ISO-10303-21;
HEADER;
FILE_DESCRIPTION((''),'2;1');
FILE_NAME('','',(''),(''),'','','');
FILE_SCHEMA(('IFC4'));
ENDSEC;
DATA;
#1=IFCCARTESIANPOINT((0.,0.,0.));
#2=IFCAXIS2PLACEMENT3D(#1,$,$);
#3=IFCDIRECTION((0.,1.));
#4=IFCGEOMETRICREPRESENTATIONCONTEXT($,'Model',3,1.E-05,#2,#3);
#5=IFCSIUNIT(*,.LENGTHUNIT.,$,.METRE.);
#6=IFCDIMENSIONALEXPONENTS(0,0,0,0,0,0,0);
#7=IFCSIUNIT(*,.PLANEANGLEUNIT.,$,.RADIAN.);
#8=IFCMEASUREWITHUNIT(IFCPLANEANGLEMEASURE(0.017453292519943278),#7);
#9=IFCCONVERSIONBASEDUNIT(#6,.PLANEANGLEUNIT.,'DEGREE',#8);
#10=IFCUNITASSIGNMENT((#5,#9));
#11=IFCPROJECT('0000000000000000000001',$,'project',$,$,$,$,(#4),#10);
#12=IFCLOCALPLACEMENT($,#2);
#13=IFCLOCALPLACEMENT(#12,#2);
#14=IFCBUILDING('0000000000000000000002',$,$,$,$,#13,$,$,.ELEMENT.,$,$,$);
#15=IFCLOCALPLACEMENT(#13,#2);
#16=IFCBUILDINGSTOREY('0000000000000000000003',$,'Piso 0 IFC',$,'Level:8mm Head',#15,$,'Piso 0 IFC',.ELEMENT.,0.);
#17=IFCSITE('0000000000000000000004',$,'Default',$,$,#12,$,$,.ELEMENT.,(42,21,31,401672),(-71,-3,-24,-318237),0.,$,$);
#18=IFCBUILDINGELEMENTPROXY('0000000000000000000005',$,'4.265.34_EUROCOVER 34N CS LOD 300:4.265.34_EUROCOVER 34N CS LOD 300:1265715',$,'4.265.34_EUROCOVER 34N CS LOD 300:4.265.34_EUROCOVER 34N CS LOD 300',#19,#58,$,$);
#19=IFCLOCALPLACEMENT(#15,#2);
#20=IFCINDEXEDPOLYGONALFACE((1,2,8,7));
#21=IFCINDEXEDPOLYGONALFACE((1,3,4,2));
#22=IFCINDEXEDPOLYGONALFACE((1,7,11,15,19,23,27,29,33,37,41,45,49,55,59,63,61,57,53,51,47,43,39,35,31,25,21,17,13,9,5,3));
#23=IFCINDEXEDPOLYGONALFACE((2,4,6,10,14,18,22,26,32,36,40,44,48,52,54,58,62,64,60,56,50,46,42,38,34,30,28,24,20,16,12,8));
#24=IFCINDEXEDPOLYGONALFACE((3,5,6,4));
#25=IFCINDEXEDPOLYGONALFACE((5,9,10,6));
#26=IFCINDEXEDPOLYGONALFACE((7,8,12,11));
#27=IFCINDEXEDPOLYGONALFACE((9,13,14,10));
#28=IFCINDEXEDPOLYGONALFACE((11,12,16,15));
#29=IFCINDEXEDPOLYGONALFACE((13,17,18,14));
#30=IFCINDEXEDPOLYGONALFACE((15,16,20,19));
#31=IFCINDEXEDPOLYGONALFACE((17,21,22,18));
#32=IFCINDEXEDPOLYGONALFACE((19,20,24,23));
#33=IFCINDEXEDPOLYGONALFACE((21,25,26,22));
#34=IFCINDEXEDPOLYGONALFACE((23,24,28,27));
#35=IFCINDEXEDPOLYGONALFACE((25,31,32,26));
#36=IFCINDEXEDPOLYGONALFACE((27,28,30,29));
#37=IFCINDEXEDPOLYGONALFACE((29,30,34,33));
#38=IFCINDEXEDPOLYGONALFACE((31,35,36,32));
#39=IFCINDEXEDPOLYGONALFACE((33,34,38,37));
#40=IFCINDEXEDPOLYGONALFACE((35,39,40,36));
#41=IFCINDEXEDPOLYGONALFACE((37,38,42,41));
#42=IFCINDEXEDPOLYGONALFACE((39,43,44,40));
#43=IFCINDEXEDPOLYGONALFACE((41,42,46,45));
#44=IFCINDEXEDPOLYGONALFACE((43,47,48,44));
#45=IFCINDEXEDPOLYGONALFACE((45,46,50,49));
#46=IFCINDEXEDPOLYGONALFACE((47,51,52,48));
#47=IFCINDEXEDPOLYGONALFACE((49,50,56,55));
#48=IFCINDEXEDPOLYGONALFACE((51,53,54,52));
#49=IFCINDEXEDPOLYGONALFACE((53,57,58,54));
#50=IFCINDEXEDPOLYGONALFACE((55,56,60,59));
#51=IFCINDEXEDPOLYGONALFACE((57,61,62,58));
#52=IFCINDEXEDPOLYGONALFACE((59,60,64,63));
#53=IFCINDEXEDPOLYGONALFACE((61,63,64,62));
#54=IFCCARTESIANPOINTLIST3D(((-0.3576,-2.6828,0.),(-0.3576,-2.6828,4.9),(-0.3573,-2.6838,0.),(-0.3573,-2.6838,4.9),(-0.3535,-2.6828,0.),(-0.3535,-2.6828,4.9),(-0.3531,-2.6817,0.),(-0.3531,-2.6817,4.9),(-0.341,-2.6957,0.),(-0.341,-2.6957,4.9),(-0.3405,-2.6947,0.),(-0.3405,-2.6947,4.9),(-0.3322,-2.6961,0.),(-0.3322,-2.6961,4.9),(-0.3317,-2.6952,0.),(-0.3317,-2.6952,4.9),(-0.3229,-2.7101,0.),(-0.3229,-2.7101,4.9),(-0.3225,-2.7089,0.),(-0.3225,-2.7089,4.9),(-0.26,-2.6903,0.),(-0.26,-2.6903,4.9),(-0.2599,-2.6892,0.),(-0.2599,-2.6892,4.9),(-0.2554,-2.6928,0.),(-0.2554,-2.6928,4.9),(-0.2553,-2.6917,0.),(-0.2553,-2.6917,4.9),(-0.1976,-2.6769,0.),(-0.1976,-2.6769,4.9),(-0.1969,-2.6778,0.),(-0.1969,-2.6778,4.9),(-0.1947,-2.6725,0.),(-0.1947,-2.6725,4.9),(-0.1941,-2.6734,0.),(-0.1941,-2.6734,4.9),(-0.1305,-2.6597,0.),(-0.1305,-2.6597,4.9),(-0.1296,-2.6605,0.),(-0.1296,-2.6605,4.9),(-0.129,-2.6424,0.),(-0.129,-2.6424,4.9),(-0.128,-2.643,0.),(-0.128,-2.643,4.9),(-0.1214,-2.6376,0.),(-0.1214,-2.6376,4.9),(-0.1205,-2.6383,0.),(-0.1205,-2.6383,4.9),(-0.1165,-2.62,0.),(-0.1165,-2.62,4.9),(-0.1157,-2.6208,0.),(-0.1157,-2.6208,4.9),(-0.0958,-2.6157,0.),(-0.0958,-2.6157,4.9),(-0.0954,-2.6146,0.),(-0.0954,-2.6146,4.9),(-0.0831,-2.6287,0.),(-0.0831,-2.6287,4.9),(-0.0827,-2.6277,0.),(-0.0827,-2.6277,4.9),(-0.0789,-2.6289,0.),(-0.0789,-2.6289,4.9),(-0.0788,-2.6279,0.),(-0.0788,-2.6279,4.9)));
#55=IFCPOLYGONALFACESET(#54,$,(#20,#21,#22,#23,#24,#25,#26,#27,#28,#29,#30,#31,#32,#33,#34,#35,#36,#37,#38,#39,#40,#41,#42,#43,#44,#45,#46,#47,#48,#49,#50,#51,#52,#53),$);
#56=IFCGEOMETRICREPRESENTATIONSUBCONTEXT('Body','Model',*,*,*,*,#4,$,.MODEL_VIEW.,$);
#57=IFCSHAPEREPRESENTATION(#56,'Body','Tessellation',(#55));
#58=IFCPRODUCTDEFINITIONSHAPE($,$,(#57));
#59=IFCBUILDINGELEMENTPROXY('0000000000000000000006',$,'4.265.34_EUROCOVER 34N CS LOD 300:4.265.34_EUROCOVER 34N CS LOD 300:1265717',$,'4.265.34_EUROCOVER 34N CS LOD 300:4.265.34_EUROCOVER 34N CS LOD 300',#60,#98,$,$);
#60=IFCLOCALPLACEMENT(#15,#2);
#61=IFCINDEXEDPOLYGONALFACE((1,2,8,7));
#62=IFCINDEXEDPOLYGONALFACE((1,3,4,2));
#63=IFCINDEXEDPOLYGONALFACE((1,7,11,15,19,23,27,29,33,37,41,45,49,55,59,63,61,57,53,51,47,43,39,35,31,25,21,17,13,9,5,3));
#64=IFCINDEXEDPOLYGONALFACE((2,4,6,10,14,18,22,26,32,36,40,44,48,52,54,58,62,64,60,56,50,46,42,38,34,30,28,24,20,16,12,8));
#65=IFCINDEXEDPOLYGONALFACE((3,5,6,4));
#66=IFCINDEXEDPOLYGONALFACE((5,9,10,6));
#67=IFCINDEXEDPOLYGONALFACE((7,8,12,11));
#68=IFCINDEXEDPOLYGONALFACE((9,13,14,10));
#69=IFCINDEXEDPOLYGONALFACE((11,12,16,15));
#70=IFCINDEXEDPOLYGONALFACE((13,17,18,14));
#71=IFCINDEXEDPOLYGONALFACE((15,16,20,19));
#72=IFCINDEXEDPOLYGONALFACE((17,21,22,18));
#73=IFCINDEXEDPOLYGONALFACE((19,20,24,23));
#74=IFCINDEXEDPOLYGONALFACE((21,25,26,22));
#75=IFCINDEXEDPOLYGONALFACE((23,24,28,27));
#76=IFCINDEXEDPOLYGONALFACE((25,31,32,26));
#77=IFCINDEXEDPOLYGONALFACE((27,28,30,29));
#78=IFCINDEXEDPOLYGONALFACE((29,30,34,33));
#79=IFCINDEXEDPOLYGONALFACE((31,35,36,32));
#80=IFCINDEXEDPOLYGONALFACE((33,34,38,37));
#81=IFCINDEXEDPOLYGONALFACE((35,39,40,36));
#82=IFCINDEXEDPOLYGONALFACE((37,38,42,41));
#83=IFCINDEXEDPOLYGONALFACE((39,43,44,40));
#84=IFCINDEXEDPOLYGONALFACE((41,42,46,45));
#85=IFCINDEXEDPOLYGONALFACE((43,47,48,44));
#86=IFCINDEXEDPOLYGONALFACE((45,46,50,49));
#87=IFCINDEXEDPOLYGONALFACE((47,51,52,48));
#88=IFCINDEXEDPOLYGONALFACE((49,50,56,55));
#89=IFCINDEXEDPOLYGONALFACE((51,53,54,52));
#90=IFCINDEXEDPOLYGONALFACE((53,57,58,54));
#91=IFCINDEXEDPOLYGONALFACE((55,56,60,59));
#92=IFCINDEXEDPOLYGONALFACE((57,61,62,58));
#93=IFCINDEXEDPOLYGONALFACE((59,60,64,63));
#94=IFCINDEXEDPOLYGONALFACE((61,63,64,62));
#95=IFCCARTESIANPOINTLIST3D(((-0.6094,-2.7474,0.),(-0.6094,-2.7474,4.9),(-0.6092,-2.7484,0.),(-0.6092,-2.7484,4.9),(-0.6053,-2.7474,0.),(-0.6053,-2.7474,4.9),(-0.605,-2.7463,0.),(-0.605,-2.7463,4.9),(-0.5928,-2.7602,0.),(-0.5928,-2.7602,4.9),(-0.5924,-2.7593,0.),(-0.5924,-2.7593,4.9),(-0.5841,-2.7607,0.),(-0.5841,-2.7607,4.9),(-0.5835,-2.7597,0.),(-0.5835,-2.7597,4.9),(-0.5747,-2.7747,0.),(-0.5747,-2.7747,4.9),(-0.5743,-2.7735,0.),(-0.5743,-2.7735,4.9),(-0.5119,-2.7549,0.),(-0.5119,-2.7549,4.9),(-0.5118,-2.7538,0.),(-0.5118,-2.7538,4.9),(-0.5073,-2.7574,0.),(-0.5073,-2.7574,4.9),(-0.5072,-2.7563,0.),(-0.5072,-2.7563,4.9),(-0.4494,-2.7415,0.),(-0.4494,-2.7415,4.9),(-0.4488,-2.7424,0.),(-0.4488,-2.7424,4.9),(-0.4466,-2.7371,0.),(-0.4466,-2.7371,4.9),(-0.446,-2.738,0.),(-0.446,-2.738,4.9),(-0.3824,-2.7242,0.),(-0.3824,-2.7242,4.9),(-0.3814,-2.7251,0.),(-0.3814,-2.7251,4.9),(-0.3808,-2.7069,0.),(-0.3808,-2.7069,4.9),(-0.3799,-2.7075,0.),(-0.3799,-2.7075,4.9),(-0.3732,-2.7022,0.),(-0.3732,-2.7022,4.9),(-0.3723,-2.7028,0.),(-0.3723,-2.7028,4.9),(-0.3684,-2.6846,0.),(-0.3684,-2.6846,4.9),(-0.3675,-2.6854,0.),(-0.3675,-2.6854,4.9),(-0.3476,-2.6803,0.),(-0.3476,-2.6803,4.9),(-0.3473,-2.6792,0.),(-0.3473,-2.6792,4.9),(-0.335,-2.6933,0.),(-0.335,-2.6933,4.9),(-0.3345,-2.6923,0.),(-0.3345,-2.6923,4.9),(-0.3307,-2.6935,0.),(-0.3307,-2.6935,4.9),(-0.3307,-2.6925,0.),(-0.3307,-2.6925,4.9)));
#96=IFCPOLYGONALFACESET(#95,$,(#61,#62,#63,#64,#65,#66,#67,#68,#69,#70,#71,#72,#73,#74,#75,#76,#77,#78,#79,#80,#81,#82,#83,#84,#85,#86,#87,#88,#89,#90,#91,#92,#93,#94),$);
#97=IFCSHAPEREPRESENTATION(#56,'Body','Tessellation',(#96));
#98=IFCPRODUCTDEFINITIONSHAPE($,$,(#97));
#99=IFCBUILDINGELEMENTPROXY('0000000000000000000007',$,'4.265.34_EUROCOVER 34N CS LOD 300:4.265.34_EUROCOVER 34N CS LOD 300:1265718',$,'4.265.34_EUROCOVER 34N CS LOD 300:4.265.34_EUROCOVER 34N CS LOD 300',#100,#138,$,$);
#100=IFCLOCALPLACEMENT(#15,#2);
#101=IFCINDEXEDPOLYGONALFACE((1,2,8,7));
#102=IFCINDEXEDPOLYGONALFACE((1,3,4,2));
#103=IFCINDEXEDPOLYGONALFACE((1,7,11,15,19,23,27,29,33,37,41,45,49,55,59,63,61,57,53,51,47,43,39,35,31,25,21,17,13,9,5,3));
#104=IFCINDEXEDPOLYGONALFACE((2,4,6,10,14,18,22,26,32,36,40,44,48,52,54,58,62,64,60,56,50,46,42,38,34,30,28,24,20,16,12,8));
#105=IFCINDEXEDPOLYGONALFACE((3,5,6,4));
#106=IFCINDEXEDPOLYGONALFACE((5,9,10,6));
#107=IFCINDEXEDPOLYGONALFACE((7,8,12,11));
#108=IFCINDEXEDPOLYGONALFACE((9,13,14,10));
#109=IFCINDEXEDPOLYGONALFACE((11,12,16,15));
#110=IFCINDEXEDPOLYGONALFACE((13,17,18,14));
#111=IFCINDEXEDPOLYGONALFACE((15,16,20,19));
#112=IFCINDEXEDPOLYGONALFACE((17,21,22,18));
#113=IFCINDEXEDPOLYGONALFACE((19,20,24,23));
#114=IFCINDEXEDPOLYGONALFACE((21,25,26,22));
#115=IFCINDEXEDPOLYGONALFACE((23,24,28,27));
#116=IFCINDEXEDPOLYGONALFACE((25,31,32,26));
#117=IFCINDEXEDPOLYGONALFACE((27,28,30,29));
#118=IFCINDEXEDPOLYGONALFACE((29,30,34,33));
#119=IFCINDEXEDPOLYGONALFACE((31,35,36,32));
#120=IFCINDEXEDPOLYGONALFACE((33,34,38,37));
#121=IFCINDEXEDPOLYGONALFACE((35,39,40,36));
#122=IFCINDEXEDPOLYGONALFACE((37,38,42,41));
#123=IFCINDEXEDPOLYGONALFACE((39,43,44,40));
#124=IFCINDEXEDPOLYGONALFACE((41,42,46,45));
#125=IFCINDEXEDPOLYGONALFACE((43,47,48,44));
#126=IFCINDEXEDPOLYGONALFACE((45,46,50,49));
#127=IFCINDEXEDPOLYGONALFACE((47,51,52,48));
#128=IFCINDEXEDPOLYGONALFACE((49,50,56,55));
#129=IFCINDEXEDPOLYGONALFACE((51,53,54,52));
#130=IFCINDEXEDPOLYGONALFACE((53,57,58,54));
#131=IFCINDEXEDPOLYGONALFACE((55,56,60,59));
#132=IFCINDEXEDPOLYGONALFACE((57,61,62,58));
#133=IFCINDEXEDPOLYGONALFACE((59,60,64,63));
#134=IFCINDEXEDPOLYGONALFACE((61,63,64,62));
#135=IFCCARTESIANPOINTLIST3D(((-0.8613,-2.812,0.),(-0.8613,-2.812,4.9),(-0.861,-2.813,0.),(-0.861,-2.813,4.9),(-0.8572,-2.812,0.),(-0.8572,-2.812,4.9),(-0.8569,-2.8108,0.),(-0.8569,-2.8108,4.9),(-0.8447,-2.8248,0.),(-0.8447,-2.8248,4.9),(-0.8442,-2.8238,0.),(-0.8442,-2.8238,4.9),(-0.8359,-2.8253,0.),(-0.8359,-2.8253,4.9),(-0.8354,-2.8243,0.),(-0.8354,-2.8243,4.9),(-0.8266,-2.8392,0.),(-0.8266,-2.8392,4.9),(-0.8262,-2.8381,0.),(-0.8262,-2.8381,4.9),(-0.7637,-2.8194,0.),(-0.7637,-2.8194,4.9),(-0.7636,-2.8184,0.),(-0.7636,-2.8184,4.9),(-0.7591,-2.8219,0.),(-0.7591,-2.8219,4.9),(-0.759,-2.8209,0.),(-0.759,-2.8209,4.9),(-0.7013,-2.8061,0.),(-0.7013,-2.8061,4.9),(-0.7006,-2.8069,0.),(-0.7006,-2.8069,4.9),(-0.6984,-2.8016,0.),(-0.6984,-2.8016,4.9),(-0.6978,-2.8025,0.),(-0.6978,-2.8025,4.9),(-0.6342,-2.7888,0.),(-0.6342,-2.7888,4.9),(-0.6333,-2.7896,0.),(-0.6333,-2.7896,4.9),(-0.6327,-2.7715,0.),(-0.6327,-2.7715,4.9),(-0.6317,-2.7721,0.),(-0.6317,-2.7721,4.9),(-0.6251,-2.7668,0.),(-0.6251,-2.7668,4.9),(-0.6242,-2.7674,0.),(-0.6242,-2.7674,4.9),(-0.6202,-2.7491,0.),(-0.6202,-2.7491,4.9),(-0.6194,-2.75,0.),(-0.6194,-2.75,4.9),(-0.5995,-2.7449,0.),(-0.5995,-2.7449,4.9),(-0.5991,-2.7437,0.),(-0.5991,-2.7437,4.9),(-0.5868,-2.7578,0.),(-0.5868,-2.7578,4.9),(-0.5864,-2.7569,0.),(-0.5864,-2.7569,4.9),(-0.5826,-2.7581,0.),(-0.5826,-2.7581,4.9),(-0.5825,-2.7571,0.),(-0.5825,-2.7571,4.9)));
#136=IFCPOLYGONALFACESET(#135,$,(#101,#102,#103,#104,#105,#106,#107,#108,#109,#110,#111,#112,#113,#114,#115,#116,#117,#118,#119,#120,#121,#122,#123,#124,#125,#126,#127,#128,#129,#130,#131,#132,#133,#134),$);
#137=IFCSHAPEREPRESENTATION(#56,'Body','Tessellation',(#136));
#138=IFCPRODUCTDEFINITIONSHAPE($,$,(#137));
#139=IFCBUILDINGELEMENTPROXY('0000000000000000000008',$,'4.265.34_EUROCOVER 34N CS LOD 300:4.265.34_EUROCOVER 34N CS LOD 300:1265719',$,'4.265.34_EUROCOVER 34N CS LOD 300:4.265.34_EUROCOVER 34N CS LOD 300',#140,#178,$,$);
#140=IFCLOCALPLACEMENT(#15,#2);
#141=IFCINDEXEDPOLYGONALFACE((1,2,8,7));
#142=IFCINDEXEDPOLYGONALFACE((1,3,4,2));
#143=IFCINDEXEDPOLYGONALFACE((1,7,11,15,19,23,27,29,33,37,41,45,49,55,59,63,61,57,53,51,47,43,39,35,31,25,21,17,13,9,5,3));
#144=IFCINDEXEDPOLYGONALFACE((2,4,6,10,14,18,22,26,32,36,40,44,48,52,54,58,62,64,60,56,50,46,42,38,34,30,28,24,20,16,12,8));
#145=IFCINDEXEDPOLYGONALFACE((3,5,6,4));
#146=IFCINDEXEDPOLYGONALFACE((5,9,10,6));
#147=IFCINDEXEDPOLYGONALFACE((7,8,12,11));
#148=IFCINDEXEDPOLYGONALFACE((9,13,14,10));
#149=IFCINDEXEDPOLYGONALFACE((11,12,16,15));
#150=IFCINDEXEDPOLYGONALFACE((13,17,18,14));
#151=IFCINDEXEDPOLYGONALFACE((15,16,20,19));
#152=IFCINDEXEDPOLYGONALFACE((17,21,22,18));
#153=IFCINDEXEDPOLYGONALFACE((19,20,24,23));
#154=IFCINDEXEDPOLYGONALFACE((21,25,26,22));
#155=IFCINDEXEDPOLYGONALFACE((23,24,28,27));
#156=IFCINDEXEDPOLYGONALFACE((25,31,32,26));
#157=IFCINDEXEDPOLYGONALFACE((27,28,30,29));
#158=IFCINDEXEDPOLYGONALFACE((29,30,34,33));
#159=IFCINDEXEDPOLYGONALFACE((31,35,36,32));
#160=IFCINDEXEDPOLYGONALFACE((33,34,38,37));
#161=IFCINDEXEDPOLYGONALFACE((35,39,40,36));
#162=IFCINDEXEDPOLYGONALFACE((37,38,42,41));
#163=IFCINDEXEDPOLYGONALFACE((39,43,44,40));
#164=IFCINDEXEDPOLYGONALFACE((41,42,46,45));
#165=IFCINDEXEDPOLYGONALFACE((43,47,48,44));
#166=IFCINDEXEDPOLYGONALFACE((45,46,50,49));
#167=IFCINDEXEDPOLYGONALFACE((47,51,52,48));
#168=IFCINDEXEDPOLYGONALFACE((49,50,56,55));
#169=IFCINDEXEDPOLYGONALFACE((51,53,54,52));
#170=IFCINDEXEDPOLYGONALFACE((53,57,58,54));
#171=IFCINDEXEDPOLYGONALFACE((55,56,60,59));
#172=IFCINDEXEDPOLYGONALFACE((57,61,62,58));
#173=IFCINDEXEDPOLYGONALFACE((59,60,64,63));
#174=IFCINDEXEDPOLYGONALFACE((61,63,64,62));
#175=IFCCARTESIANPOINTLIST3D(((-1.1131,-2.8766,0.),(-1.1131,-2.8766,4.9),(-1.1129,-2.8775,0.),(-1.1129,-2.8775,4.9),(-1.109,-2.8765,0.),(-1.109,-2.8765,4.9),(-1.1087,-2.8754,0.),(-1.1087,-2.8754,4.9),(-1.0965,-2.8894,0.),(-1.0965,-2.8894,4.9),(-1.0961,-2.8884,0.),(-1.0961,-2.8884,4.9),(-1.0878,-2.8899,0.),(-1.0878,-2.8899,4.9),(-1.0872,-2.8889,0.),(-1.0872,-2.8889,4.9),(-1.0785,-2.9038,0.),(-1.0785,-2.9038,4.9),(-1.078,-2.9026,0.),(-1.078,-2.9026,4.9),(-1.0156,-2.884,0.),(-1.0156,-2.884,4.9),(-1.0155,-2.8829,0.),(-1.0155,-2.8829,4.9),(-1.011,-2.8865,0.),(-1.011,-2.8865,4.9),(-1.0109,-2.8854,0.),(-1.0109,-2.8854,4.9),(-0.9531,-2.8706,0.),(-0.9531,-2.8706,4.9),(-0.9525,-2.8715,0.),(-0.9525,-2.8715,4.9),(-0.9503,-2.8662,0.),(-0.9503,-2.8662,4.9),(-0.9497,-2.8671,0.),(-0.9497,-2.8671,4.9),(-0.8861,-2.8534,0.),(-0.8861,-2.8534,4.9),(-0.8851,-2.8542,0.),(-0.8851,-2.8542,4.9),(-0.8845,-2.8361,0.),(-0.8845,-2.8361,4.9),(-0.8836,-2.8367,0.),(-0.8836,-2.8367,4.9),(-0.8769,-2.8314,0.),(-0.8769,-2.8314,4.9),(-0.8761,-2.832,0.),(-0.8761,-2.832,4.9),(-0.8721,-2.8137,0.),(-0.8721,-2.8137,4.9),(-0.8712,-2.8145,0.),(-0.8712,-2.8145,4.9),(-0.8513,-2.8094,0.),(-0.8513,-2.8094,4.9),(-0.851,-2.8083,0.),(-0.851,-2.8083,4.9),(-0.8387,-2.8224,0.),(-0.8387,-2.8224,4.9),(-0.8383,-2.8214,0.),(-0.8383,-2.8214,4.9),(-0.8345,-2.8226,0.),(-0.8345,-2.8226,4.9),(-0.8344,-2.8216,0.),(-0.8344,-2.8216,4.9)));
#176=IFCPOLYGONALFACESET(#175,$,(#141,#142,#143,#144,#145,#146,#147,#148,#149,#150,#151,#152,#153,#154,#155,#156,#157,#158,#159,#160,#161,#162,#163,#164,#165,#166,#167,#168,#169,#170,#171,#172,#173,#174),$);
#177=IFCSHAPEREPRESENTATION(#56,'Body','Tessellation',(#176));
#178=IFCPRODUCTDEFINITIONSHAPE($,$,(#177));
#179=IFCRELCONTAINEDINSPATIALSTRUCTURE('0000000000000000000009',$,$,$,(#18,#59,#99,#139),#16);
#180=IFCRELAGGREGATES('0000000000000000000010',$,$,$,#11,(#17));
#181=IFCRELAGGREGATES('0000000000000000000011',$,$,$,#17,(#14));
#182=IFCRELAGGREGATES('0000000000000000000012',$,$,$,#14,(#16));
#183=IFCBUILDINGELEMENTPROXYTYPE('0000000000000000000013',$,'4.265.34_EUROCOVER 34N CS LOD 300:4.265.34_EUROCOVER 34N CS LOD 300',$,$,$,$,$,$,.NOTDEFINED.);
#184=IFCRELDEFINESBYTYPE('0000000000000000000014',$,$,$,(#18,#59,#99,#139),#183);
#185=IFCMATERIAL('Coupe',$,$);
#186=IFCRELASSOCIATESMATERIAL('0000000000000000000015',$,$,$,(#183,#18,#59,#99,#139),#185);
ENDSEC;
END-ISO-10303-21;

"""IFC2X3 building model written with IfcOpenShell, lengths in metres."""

from ifc_helpers import new_model, entity, si_unit, converted_unit, direction, frame, origin, place, context, subcontext, project, spatial, polyline, outline, extrude, source, transform, mapped, material, type_object, type_shapes, element, save


model = new_model("IFC2X3")

# Units and contexts
model_context = context("Model", 3, precision=1e-05, world=origin(), true_north=direction((0.0, 1.0)))
body_context = subcontext(model_context, "Body", "Model", "MODEL_VIEW")
ifc_project = project(units=[si_unit("LENGTHUNIT", "METRE"), converted_unit("PLANEANGLEUNIT", "DEGREE", entity("IfcPlaneAngleMeasure", 0.017453292519943278), si_unit("PLANEANGLEUNIT", "RADIAN"), dimensions=[0, 0, 0, 0, 0, 0, 0])], contexts=[model_context])

# Site, building, storey
site_placement = place(None, origin())
site = spatial("IfcSite", under=ifc_project, at=site_placement, Name="Default", CompositionType="ELEMENT", RefLatitude=(42, 21, 31, 401672), RefLongitude=(-71, -3, -24, -318237), RefElevation=0.0)
building_placement = place(site_placement, origin())
building = spatial("IfcBuilding", under=site, at=building_placement, CompositionType="ELEMENT")
storey_placement = place(building_placement, origin())
storey = spatial("IfcBuildingStorey", under=building, at=storey_placement, Name="Piso 0 IFC", ObjectType="Level:8mm Head", LongName="Piso 0 IFC", CompositionType="ELEMENT", Elevation=0.0)

# Building element proxies
ifc_material_1 = material(Name="Coupe")
building_element_proxy_type = type_object("IfcBuildingElementProxyType", Name="4.265.34_EUROCOVER 34N CS LOD 300:4.265.34_EUROCOVER 34N CS LOD 300", PredefinedType="NOTDEFINED", material=ifc_material_1)
shared_shape_1 = source(origin(), body_context, "Body", "SweptSolid", [
    extrude(outline(polyline([(0.0449, 0.1162), (0.063, 0.1162), (0.0661, 0.1191), (0.0654, 0.1198), (0.0626, 0.1172), (0.0443, 0.1172), (0.0335, 0.0983), (0.0428, 0.0826), (0.0409, 0.0738), (0.0522, 0.0606), (0.0167, 0.0056), (0.0179, 0.0005), (-0.0117, -0.0512), (-0.0167, -0.0528), (-0.0462, -0.1114), (-0.0624, -0.1084), (-0.069, -0.1145), (-0.0871, -0.1145), (-0.0893, -0.1184), (-0.0885, -0.1189), (-0.0865, -0.1155), (-0.0686, -0.1155), (-0.0621, -0.1095), (-0.0456, -0.1125), (-0.016, -0.0536), (-0.0111, -0.0521), (0.0189, 0.0004), (0.0177, 0.0054), (0.0535, 0.0607), (0.0419, 0.074), (0.0438, 0.0827), (0.0347, 0.0983), (0.0449, 0.1162)])), frame((-0.0171, -0.0163, 0.0), z_axis=(0.0, 0.0, 1.0), x_axis=(-0.496574, 0.867994, 0.0)), (0.0, 0.0, 1.0), 4.9),
])
type_shapes(building_element_proxy_type, [shared_shape_1])
for number, where, z_axis, x_axis, name in (
    (1, (-0.2229, -2.6845, 0.0), (0.0, 0.0, 1.0), (-0.968666, -0.248367, 0.0), "4.265.34_EUROCOVER 34N CS LOD 300:4.265.34_EUROCOVER 34N CS LOD 300:1265715"),
    (2, (-0.4748, -2.749, 0.0), (0.0, 0.0, 1.0), (-0.968666, -0.248367, 0.0), "4.265.34_EUROCOVER 34N CS LOD 300:4.265.34_EUROCOVER 34N CS LOD 300:1265717"),
    (3, (-0.7267, -2.8136, 0.0), (0.0, 0.0, 1.0), (-0.968666, -0.248367, 0.0), "4.265.34_EUROCOVER 34N CS LOD 300:4.265.34_EUROCOVER 34N CS LOD 300:1265718"),
    (4, (-0.9785, -2.8782, 0.0), (0.0, 0.0, 1.0), (-0.968666, -0.248367, 0.0), "4.265.34_EUROCOVER 34N CS LOD 300:4.265.34_EUROCOVER 34N CS LOD 300:1265719"),
):
    element("IfcBuildingElementProxy", number, at=place(storey_placement, frame(where, z_axis=z_axis, x_axis=x_axis)), inside=storey, type_object=building_element_proxy_type, material=ifc_material_1, Name=name, ObjectType="4.265.34_EUROCOVER 34N CS LOD 300:4.265.34_EUROCOVER 34N CS LOD 300", context=body_context, shape_type="MappedRepresentation", body=[
        mapped(shared_shape_1, transform((0.0, 0.0, 0.0), scale=1.0)),
    ])

save(model, "model.ifc")
